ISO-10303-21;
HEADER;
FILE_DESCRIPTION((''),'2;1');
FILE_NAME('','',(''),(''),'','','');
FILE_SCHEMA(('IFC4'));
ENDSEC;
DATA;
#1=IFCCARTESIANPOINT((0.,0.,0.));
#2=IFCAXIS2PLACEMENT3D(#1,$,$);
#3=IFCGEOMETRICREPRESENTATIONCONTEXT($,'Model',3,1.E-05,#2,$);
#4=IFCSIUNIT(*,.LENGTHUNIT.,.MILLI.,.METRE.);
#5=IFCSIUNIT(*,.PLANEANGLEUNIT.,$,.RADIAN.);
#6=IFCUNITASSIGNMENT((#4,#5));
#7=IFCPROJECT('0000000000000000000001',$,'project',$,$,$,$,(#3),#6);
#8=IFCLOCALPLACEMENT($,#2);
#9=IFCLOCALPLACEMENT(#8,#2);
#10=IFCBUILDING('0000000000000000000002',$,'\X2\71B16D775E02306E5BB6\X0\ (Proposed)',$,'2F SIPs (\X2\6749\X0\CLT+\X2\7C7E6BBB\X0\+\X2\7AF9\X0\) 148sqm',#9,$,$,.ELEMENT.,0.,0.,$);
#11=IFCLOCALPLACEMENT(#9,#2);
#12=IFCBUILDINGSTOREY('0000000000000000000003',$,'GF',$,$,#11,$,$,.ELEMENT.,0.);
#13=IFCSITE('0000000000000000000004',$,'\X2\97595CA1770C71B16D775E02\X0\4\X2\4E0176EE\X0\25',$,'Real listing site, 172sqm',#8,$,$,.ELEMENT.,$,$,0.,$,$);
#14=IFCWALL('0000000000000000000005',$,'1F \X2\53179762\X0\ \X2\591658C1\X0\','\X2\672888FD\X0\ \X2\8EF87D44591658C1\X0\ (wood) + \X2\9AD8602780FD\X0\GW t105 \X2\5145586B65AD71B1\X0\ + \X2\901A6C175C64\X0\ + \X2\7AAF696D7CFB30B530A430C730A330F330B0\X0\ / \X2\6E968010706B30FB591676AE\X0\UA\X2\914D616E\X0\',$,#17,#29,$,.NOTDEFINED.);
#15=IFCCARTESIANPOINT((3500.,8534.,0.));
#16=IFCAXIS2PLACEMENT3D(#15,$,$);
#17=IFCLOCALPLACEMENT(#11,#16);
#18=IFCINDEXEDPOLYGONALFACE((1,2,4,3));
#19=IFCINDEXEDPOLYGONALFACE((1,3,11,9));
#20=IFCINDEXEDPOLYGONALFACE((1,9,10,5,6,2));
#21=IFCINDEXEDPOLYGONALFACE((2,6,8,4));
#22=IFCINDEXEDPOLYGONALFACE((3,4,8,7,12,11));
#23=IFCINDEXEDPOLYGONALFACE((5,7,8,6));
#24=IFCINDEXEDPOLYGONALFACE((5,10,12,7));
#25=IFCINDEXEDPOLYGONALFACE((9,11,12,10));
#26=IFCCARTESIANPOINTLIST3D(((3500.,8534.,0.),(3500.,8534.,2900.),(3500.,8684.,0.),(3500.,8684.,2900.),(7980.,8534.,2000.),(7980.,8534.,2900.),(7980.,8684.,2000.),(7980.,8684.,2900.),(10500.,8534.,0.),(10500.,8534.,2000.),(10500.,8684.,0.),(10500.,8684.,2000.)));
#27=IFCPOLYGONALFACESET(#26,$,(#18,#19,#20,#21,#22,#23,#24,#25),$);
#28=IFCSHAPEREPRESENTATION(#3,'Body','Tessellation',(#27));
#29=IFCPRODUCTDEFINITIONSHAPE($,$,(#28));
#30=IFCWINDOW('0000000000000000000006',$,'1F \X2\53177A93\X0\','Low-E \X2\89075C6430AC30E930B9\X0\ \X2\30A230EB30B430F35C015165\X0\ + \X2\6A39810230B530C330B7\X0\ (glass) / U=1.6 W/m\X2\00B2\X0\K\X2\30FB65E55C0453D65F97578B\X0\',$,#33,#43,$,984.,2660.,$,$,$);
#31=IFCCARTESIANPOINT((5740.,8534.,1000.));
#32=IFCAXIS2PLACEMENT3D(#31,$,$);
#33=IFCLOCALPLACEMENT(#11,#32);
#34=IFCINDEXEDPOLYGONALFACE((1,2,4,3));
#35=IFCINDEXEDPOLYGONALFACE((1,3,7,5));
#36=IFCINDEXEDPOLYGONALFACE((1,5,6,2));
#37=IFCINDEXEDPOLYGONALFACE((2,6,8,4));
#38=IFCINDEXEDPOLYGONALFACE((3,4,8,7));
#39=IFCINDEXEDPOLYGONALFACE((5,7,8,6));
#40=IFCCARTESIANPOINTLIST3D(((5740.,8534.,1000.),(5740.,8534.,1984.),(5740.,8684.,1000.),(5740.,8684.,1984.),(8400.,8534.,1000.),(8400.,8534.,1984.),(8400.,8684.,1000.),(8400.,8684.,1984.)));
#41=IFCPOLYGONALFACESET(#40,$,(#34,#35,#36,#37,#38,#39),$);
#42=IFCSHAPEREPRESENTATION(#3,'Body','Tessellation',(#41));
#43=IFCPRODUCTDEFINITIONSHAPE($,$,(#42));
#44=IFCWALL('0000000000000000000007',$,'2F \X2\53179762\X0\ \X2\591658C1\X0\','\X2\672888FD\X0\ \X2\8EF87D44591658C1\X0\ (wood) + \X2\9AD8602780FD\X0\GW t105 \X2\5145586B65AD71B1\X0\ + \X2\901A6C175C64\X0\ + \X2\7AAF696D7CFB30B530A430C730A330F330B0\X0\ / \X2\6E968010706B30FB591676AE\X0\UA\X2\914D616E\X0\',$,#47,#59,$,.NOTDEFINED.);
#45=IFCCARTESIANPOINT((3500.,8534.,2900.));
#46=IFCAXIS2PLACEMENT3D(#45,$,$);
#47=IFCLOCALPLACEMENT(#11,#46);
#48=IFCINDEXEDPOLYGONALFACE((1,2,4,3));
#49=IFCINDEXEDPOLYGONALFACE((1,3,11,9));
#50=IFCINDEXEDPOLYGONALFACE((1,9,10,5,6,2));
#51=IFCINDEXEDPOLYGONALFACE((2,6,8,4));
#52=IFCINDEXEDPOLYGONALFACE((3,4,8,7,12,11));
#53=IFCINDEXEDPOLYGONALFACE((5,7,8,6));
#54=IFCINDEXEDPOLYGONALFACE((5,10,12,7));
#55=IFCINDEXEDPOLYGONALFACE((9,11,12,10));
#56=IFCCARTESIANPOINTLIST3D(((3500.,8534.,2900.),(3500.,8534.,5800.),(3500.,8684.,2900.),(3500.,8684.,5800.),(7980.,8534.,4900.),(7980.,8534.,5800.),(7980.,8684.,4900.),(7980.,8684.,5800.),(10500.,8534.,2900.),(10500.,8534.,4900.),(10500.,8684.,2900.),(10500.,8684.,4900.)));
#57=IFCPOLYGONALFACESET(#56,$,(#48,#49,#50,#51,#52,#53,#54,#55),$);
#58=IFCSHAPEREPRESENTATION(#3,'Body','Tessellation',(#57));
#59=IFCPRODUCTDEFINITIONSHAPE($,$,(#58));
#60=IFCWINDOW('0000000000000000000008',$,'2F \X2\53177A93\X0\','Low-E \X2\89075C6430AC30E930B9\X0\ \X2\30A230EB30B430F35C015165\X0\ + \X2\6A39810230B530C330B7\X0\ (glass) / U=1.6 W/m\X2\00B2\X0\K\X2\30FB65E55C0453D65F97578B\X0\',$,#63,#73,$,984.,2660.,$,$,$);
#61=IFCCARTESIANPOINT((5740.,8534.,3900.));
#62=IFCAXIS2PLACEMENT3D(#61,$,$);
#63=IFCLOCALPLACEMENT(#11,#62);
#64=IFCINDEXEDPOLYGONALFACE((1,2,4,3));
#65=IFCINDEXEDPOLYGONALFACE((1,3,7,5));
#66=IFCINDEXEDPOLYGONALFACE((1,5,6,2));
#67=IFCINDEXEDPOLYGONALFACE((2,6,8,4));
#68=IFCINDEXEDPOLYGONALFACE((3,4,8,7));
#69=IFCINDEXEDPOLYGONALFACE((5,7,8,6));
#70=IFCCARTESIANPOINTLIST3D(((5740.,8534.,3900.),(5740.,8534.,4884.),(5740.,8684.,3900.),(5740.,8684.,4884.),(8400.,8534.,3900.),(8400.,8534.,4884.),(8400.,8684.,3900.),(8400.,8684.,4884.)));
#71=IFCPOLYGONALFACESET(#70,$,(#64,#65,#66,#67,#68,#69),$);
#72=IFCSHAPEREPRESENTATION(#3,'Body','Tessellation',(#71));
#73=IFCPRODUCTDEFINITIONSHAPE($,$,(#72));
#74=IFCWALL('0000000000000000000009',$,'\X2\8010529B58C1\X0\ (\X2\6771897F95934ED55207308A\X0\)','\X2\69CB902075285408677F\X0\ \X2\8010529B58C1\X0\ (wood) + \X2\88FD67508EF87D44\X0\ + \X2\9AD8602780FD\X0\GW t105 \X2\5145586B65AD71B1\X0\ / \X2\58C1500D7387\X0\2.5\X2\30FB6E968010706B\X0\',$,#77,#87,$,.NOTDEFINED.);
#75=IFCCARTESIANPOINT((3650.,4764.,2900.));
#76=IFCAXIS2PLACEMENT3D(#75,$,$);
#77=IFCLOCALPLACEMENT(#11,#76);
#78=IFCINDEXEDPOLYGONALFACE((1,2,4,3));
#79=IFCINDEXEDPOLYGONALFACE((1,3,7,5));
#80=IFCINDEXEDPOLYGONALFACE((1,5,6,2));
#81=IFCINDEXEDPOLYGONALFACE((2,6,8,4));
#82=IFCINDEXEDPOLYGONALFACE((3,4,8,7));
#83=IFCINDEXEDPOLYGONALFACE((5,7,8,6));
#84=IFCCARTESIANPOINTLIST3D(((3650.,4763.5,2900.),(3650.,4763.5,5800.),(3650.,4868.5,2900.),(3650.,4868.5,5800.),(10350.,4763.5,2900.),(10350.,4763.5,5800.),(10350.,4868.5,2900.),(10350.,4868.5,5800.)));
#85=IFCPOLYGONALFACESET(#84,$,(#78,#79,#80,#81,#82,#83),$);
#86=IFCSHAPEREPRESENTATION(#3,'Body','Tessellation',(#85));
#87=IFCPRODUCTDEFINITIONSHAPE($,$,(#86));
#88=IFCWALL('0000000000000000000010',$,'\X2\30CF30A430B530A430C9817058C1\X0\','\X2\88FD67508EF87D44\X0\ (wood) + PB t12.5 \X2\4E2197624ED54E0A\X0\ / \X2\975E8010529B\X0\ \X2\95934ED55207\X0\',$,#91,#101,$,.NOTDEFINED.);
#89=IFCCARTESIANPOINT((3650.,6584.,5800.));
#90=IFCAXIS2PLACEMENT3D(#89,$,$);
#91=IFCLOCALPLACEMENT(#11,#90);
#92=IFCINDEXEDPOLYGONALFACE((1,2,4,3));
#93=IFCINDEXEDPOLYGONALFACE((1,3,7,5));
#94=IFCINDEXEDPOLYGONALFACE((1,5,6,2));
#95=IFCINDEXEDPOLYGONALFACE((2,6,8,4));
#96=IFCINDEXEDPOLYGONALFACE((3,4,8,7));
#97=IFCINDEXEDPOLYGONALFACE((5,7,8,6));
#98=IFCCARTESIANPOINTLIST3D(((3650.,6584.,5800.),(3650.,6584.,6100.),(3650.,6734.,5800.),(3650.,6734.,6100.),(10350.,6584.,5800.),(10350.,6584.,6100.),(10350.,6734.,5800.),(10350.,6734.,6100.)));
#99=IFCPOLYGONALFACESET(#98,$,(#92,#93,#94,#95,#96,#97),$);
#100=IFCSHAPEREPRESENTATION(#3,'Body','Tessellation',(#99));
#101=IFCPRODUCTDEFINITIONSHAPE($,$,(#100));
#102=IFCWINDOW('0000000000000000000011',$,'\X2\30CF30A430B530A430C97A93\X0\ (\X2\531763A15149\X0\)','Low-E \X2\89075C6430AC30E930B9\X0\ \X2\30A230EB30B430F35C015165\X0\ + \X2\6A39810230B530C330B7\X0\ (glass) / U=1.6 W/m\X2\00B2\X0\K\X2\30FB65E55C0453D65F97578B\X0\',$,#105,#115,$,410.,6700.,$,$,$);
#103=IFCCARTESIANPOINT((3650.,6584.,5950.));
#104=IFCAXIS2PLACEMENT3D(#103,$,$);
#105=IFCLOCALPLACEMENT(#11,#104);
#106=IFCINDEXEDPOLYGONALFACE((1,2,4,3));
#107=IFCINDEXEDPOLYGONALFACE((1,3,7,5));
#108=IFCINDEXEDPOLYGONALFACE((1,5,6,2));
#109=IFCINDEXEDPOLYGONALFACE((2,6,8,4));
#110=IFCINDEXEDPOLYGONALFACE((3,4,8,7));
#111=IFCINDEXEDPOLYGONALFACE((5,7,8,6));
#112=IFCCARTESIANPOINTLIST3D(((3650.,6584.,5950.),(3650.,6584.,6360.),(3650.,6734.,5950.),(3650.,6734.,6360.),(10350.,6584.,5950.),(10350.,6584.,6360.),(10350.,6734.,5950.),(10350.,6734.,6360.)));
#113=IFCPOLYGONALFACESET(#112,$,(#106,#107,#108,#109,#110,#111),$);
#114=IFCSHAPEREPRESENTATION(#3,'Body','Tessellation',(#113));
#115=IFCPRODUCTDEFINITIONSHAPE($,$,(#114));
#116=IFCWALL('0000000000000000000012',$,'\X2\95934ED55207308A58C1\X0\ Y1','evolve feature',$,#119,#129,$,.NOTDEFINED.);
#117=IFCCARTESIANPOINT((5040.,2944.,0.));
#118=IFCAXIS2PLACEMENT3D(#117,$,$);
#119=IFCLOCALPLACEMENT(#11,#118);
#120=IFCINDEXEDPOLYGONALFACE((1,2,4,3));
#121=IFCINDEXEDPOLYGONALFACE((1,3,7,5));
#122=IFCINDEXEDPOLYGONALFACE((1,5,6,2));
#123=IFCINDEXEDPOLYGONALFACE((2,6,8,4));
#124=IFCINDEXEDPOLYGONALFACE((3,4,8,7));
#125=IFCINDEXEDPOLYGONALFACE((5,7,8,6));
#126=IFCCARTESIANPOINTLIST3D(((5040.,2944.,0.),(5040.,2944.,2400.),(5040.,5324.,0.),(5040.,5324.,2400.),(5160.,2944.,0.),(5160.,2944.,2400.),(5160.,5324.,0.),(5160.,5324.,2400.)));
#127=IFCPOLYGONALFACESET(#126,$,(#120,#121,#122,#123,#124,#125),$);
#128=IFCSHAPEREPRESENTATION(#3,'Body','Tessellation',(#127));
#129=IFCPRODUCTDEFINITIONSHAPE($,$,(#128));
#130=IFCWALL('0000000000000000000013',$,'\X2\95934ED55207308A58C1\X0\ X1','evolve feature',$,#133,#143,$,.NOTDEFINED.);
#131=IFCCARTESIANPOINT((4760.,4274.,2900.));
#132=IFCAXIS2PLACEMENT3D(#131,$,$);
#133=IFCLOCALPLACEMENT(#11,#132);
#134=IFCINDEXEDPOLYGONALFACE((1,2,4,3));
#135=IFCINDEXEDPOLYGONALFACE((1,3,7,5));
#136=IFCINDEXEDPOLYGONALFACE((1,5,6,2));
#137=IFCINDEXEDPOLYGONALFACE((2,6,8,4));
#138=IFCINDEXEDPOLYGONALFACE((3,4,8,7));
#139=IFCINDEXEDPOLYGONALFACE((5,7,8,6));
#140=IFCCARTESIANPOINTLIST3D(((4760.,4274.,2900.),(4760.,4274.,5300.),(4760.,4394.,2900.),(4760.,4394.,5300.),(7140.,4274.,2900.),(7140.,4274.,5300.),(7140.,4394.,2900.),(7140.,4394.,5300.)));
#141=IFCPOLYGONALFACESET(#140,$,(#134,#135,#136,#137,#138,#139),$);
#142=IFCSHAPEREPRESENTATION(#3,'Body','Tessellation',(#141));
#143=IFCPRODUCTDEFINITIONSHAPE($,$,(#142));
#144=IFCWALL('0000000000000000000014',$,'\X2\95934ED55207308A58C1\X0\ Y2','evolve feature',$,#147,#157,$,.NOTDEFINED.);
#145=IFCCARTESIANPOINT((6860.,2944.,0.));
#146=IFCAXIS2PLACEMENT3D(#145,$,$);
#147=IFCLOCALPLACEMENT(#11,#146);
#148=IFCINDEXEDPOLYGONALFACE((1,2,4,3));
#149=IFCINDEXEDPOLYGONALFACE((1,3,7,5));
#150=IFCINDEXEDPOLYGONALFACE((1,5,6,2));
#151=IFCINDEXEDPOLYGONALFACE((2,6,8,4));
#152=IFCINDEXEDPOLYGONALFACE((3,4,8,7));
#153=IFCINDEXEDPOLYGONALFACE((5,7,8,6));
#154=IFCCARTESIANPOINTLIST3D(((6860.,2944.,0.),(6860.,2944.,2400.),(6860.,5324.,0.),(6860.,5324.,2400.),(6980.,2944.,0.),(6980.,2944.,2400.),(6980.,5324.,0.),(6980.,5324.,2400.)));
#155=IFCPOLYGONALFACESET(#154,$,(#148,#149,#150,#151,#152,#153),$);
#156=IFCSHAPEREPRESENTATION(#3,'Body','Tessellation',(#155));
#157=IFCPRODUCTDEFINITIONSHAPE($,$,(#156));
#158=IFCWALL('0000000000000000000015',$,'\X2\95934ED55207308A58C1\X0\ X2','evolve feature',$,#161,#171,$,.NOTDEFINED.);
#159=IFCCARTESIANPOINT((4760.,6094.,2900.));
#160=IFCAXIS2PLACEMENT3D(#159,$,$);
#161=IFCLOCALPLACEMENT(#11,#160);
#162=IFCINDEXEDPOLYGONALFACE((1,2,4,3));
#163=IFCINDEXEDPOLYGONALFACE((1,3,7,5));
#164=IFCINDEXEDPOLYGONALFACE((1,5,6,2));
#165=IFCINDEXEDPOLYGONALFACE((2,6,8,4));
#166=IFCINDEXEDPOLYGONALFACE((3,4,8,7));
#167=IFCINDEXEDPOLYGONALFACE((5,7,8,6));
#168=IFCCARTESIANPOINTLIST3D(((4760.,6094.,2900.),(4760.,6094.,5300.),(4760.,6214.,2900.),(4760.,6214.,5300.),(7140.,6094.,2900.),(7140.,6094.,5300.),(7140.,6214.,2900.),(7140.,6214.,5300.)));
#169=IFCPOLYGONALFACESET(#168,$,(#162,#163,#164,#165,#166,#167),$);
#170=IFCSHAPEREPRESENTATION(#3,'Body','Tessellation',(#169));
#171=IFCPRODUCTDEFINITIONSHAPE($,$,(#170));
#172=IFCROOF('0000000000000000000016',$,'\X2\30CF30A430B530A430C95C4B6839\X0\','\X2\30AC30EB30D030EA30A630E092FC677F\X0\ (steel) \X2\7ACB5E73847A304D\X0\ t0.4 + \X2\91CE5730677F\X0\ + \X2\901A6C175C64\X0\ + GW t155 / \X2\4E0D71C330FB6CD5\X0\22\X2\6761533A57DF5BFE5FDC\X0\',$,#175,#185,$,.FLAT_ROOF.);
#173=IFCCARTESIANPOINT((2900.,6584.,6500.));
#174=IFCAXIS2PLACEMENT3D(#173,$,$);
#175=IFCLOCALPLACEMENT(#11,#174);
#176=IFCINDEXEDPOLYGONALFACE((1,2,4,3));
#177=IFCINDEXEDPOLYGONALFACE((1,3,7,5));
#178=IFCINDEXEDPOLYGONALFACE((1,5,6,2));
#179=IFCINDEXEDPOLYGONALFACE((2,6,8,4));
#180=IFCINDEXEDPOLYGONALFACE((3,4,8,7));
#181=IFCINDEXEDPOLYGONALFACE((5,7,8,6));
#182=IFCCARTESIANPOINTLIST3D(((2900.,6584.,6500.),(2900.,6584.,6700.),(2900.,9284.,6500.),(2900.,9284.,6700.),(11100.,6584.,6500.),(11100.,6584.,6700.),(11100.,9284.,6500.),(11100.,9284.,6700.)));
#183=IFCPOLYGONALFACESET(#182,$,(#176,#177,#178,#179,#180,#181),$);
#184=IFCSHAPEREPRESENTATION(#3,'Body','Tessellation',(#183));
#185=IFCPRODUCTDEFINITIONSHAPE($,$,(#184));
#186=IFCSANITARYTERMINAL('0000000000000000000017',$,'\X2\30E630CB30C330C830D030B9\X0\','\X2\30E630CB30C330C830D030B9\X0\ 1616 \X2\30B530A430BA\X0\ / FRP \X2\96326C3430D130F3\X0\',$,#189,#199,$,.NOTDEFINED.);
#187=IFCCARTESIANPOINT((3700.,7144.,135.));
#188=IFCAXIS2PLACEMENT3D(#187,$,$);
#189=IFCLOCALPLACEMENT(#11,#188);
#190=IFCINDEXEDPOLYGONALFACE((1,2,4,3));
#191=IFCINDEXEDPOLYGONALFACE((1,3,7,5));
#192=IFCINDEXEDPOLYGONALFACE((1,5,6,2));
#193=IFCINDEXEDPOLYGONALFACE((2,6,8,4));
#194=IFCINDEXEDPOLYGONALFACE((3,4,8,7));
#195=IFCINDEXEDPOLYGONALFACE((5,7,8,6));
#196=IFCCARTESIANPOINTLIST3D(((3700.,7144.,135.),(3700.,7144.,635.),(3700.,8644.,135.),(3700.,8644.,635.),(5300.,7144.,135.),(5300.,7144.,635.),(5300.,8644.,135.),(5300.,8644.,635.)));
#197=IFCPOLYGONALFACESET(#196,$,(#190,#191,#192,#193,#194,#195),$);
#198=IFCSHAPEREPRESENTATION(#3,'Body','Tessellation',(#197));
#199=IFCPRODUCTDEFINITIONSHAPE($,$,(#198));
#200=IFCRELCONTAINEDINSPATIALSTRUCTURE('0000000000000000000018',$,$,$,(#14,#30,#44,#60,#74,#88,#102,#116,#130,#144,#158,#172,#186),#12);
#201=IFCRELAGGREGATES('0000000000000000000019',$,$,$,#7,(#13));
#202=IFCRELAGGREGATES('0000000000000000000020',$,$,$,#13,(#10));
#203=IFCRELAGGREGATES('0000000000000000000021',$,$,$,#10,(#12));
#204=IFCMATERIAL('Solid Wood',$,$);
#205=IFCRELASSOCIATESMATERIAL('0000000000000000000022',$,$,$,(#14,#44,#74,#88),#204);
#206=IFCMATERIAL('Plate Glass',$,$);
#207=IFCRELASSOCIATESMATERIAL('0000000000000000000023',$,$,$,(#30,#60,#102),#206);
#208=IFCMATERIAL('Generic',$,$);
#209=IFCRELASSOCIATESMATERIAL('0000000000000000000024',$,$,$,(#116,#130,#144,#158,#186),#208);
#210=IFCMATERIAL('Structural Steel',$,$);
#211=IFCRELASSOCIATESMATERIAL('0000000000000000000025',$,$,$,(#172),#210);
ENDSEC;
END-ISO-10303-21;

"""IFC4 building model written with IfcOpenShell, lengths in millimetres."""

from ifc_helpers import new_model, si_unit, frame, frame_2d, origin, place, context, project, spatial, rectangle, extrude, material, element, fill, save


model = new_model("IFC4")

# Units and contexts
model_context = context("Model", 3, precision=1e-05, world=origin())
ifc_project = project(units=[si_unit("LENGTHUNIT", "METRE", prefix="MILLI"), si_unit("PLANEANGLEUNIT", "RADIAN")], contexts=[model_context])

# Site, building, storey
site_placement = place(None, origin())
site = spatial("IfcSite", under=ifc_project, at=site_placement, Name="静岡県熱海市4丁目25", ObjectType="Real listing site, 172sqm", CompositionType="ELEMENT", RefElevation=0.0)
building_placement = place(site_placement, origin())
building = spatial("IfcBuilding", under=site, at=building_placement, Name="熱海市の家 (Proposed)", ObjectType="2F SIPs (杉CLT+籾殻+竹) 148sqm", CompositionType="ELEMENT", ElevationOfRefHeight=0.0, ElevationOfTerrain=0.0)
storey_placement = place(building_placement, origin())
storey = spatial("IfcBuildingStorey", under=building, at=storey_placement, Name="GF", CompositionType="ELEMENT", Elevation=0.0)

# Wall, opening, window
ifc_material_1 = material(Name="Solid Wood")
wall_1_placement = place(storey_placement, frame((3500.0, 8534.0, 0.0)))
wall_1 = element("IfcWall", 1, at=wall_1_placement, inside=storey, material=ifc_material_1, Name="1F 北面 外壁", Description="木製 軸組外壁 (wood) + 高性能GW t105 充填断熱 + 通気層 + 窯業系サイディング / 準耐火・外皮UA配慮", PredefinedType="NOTDEFINED", context=model_context, shape_type="SweptSolid", body=[
    extrude(rectangle(XDim=7000.0, YDim=150.0, at=frame_2d((3500.0, 75.0))), frame((3500.0, 8534.0, 0.0)), (0.0, 0.0, 1.0), 2900.0),
])
opening_1_placement = place(storey_placement, frame((5740.0, 8534.0, 1000.0)))
opening_1 = element("IfcOpeningElement", 2, at=opening_1_placement, cuts=wall_1, PredefinedType="NOTDEFINED", context=model_context, shape_type="SweptSolid", body=[
    extrude(rectangle(XDim=2660.0, YDim=150.0, at=frame_2d((1330.0, 75.0))), frame((5740.0, 8534.0, 1000.0)), (0.0, 0.0, 1.0), 984.0),
])
ifc_material_2 = material(Name="Plate Glass")
window_1_placement = place(storey_placement, frame((5740.0, 8534.0, 1000.0)))
window_1 = element("IfcWindow", 3, at=window_1_placement, inside=storey, material=ifc_material_2, Name="1F 北窓", Description="Low-E 複層ガラス アルゴン封入 + 樹脂サッシ (glass) / U=1.6 W/m²K・日射取得型", OverallHeight=984.0, OverallWidth=2660.0, context=model_context, shape_type="SweptSolid", body=[
    extrude(rectangle(XDim=2660.0, YDim=150.0, at=frame_2d((1330.0, 75.0))), frame((5740.0, 8534.0, 1000.0)), (0.0, 0.0, 1.0), 984.0),
])
fill(opening_1, window_1)

# Wall, opening, window
wall_2_placement = place(storey_placement, frame((3500.0, 8534.0, 2900.0)))
wall_2 = element("IfcWall", 4, at=wall_2_placement, inside=storey, material=ifc_material_1, Name="2F 北面 外壁", Description="木製 軸組外壁 (wood) + 高性能GW t105 充填断熱 + 通気層 + 窯業系サイディング / 準耐火・外皮UA配慮", PredefinedType="NOTDEFINED", context=model_context, shape_type="SweptSolid", body=[
    extrude(rectangle(XDim=7000.0, YDim=150.0, at=frame_2d((3500.0, 75.0))), frame((3500.0, 8534.0, 2900.0)), (0.0, 0.0, 1.0), 2900.0),
])
opening_2_placement = place(storey_placement, frame((5740.0, 8534.0, 3900.0)))
opening_2 = element("IfcOpeningElement", 5, at=opening_2_placement, cuts=wall_2, PredefinedType="NOTDEFINED", context=model_context, shape_type="SweptSolid", body=[
    extrude(rectangle(XDim=2660.0, YDim=150.0, at=frame_2d((1330.0, 75.0))), frame((5740.0, 8534.0, 3900.0)), (0.0, 0.0, 1.0), 984.0),
])
window_2_placement = place(storey_placement, frame((5740.0, 8534.0, 3900.0)))
window_2 = element("IfcWindow", 6, at=window_2_placement, inside=storey, material=ifc_material_2, Name="2F 北窓", Description="Low-E 複層ガラス アルゴン封入 + 樹脂サッシ (glass) / U=1.6 W/m²K・日射取得型", OverallHeight=984.0, OverallWidth=2660.0, context=model_context, shape_type="SweptSolid", body=[
    extrude(rectangle(XDim=2660.0, YDim=150.0, at=frame_2d((1330.0, 75.0))), frame((5740.0, 8534.0, 3900.0)), (0.0, 0.0, 1.0), 984.0),
])
fill(opening_2, window_2)

# Wall
wall_3_placement = place(storey_placement, frame((3650.0, 4764.0, 2900.0)))
element("IfcWall", 7, at=wall_3_placement, inside=storey, material=ifc_material_1, Name="耐力壁 (東西間仕切り)", Description="構造用合板 耐力壁 (wood) + 製材軸組 + 高性能GW t105 充填断熱 / 壁倍率2.5・準耐火", PredefinedType="NOTDEFINED", context=model_context, shape_type="SweptSolid", body=[
    extrude(rectangle(XDim=6700.0, YDim=105.0, at=frame_2d((3350.0, 52.0))), frame((3650.0, 4764.0, 2900.0)), (0.0, 0.0, 1.0), 2900.0),
])

# Wall, opening, window
wall_4_placement = place(storey_placement, frame((3650.0, 6584.0, 5800.0)))
wall_4 = element("IfcWall", 8, at=wall_4_placement, inside=storey, material=ifc_material_1, Name="ハイサイド腰壁", Description="製材軸組 (wood) + PB t12.5 両面仕上 / 非耐力 間仕切", PredefinedType="NOTDEFINED", context=model_context, shape_type="SweptSolid", body=[
    extrude(rectangle(XDim=6700.0, YDim=150.0, at=frame_2d((3350.0, 75.0))), frame((3650.0, 6584.0, 5800.0)), (0.0, 0.0, 1.0), 700.0),
])
opening_3_placement = place(storey_placement, frame((3650.0, 6584.0, 5950.0)))
opening_3 = element("IfcOpeningElement", 9, at=opening_3_placement, cuts=wall_4, PredefinedType="NOTDEFINED", context=model_context, shape_type="SweptSolid", body=[
    extrude(rectangle(XDim=6700.0, YDim=150.0, at=frame_2d((3350.0, 75.0))), frame((3650.0, 6584.0, 5950.0)), (0.0, 0.0, 1.0), 410.0),
])
window_3_placement = place(storey_placement, frame((3650.0, 6584.0, 5950.0)))
window_3 = element("IfcWindow", 10, at=window_3_placement, inside=storey, material=ifc_material_2, Name="ハイサイド窓 (北採光)", Description="Low-E 複層ガラス アルゴン封入 + 樹脂サッシ (glass) / U=1.6 W/m²K・日射取得型", OverallHeight=410.0, OverallWidth=6700.0, context=model_context, shape_type="SweptSolid", body=[
    extrude(rectangle(XDim=6700.0, YDim=150.0, at=frame_2d((3350.0, 75.0))), frame((3650.0, 6584.0, 5950.0)), (0.0, 0.0, 1.0), 410.0),
])
fill(opening_3, window_3)

# Walls
ifc_material_3 = material(Name="Generic")
wall_5_placement = place(storey_placement, frame((5040.0, 2944.0, 0.0)))
element("IfcWall", 11, at=wall_5_placement, inside=storey, material=ifc_material_3, Name="間仕切り壁 Y1", Description="evolve feature", PredefinedType="NOTDEFINED", context=model_context, shape_type="SweptSolid", body=[
    extrude(rectangle(XDim=120.0, YDim=2380.0, at=frame_2d((60.0, 1190.0))), frame((5040.0, 2944.0, 0.0)), (0.0, 0.0, 1.0), 2400.0),
])
wall_6_placement = place(storey_placement, frame((4760.0, 4274.0, 2900.0)))
element("IfcWall", 12, at=wall_6_placement, inside=storey, material=ifc_material_3, Name="間仕切り壁 X1", Description="evolve feature", PredefinedType="NOTDEFINED", context=model_context, shape_type="SweptSolid", body=[
    extrude(rectangle(XDim=2380.0, YDim=120.0, at=frame_2d((1190.0, 60.0))), frame((4760.0, 4274.0, 2900.0)), (0.0, 0.0, 1.0), 2400.0),
])
wall_7_placement = place(storey_placement, frame((6860.0, 2944.0, 0.0)))
element("IfcWall", 13, at=wall_7_placement, inside=storey, material=ifc_material_3, Name="間仕切り壁 Y2", Description="evolve feature", PredefinedType="NOTDEFINED", context=model_context, shape_type="SweptSolid", body=[
    extrude(rectangle(XDim=120.0, YDim=2380.0, at=frame_2d((60.0, 1190.0))), frame((6860.0, 2944.0, 0.0)), (0.0, 0.0, 1.0), 2400.0),
])
wall_8_placement = place(storey_placement, frame((4760.0, 6094.0, 2900.0)))
element("IfcWall", 14, at=wall_8_placement, inside=storey, material=ifc_material_3, Name="間仕切り壁 X2", Description="evolve feature", PredefinedType="NOTDEFINED", context=model_context, shape_type="SweptSolid", body=[
    extrude(rectangle(XDim=2380.0, YDim=120.0, at=frame_2d((1190.0, 60.0))), frame((4760.0, 6094.0, 2900.0)), (0.0, 0.0, 1.0), 2400.0),
])

# Roof
ifc_material_4 = material(Name="Structural Steel")
roof_placement = place(storey_placement, frame((2900.0, 6584.0, 6500.0)))
element("IfcRoof", 15, at=roof_placement, inside=storey, material=ifc_material_4, Name="ハイサイド屋根", Description="ガルバリウム鋼板 (steel) 立平葺き t0.4 + 野地板 + 通気層 + GW t155 / 不燃・法22条区域対応", PredefinedType="FLAT_ROOF", context=model_context, shape_type="SweptSolid", body=[
    extrude(rectangle(XDim=8200.0, YDim=2700.0, at=frame_2d((4100.0, 1350.0))), frame((2900.0, 6584.0, 6500.0)), (0.0, 0.0, 1.0), 200.0),
])

# Sanitary terminal
sanitary_terminal_1_placement = place(storey_placement, frame((3700.0, 7144.0, 135.0)))
element("IfcSanitaryTerminal", 16, at=sanitary_terminal_1_placement, inside=storey, material=ifc_material_3, Name="ユニットバス", Description="ユニットバス 1616 サイズ / FRP 防水パン", PredefinedType="NOTDEFINED", context=model_context, shape_type="SweptSolid", body=[
    extrude(rectangle(XDim=1600.0, YDim=1500.0, at=frame_2d((800.0, 750.0))), frame((3700.0, 7144.0, 135.0)), (0.0, 0.0, 1.0), 500.0),
])

save(model, "model.ifc")
